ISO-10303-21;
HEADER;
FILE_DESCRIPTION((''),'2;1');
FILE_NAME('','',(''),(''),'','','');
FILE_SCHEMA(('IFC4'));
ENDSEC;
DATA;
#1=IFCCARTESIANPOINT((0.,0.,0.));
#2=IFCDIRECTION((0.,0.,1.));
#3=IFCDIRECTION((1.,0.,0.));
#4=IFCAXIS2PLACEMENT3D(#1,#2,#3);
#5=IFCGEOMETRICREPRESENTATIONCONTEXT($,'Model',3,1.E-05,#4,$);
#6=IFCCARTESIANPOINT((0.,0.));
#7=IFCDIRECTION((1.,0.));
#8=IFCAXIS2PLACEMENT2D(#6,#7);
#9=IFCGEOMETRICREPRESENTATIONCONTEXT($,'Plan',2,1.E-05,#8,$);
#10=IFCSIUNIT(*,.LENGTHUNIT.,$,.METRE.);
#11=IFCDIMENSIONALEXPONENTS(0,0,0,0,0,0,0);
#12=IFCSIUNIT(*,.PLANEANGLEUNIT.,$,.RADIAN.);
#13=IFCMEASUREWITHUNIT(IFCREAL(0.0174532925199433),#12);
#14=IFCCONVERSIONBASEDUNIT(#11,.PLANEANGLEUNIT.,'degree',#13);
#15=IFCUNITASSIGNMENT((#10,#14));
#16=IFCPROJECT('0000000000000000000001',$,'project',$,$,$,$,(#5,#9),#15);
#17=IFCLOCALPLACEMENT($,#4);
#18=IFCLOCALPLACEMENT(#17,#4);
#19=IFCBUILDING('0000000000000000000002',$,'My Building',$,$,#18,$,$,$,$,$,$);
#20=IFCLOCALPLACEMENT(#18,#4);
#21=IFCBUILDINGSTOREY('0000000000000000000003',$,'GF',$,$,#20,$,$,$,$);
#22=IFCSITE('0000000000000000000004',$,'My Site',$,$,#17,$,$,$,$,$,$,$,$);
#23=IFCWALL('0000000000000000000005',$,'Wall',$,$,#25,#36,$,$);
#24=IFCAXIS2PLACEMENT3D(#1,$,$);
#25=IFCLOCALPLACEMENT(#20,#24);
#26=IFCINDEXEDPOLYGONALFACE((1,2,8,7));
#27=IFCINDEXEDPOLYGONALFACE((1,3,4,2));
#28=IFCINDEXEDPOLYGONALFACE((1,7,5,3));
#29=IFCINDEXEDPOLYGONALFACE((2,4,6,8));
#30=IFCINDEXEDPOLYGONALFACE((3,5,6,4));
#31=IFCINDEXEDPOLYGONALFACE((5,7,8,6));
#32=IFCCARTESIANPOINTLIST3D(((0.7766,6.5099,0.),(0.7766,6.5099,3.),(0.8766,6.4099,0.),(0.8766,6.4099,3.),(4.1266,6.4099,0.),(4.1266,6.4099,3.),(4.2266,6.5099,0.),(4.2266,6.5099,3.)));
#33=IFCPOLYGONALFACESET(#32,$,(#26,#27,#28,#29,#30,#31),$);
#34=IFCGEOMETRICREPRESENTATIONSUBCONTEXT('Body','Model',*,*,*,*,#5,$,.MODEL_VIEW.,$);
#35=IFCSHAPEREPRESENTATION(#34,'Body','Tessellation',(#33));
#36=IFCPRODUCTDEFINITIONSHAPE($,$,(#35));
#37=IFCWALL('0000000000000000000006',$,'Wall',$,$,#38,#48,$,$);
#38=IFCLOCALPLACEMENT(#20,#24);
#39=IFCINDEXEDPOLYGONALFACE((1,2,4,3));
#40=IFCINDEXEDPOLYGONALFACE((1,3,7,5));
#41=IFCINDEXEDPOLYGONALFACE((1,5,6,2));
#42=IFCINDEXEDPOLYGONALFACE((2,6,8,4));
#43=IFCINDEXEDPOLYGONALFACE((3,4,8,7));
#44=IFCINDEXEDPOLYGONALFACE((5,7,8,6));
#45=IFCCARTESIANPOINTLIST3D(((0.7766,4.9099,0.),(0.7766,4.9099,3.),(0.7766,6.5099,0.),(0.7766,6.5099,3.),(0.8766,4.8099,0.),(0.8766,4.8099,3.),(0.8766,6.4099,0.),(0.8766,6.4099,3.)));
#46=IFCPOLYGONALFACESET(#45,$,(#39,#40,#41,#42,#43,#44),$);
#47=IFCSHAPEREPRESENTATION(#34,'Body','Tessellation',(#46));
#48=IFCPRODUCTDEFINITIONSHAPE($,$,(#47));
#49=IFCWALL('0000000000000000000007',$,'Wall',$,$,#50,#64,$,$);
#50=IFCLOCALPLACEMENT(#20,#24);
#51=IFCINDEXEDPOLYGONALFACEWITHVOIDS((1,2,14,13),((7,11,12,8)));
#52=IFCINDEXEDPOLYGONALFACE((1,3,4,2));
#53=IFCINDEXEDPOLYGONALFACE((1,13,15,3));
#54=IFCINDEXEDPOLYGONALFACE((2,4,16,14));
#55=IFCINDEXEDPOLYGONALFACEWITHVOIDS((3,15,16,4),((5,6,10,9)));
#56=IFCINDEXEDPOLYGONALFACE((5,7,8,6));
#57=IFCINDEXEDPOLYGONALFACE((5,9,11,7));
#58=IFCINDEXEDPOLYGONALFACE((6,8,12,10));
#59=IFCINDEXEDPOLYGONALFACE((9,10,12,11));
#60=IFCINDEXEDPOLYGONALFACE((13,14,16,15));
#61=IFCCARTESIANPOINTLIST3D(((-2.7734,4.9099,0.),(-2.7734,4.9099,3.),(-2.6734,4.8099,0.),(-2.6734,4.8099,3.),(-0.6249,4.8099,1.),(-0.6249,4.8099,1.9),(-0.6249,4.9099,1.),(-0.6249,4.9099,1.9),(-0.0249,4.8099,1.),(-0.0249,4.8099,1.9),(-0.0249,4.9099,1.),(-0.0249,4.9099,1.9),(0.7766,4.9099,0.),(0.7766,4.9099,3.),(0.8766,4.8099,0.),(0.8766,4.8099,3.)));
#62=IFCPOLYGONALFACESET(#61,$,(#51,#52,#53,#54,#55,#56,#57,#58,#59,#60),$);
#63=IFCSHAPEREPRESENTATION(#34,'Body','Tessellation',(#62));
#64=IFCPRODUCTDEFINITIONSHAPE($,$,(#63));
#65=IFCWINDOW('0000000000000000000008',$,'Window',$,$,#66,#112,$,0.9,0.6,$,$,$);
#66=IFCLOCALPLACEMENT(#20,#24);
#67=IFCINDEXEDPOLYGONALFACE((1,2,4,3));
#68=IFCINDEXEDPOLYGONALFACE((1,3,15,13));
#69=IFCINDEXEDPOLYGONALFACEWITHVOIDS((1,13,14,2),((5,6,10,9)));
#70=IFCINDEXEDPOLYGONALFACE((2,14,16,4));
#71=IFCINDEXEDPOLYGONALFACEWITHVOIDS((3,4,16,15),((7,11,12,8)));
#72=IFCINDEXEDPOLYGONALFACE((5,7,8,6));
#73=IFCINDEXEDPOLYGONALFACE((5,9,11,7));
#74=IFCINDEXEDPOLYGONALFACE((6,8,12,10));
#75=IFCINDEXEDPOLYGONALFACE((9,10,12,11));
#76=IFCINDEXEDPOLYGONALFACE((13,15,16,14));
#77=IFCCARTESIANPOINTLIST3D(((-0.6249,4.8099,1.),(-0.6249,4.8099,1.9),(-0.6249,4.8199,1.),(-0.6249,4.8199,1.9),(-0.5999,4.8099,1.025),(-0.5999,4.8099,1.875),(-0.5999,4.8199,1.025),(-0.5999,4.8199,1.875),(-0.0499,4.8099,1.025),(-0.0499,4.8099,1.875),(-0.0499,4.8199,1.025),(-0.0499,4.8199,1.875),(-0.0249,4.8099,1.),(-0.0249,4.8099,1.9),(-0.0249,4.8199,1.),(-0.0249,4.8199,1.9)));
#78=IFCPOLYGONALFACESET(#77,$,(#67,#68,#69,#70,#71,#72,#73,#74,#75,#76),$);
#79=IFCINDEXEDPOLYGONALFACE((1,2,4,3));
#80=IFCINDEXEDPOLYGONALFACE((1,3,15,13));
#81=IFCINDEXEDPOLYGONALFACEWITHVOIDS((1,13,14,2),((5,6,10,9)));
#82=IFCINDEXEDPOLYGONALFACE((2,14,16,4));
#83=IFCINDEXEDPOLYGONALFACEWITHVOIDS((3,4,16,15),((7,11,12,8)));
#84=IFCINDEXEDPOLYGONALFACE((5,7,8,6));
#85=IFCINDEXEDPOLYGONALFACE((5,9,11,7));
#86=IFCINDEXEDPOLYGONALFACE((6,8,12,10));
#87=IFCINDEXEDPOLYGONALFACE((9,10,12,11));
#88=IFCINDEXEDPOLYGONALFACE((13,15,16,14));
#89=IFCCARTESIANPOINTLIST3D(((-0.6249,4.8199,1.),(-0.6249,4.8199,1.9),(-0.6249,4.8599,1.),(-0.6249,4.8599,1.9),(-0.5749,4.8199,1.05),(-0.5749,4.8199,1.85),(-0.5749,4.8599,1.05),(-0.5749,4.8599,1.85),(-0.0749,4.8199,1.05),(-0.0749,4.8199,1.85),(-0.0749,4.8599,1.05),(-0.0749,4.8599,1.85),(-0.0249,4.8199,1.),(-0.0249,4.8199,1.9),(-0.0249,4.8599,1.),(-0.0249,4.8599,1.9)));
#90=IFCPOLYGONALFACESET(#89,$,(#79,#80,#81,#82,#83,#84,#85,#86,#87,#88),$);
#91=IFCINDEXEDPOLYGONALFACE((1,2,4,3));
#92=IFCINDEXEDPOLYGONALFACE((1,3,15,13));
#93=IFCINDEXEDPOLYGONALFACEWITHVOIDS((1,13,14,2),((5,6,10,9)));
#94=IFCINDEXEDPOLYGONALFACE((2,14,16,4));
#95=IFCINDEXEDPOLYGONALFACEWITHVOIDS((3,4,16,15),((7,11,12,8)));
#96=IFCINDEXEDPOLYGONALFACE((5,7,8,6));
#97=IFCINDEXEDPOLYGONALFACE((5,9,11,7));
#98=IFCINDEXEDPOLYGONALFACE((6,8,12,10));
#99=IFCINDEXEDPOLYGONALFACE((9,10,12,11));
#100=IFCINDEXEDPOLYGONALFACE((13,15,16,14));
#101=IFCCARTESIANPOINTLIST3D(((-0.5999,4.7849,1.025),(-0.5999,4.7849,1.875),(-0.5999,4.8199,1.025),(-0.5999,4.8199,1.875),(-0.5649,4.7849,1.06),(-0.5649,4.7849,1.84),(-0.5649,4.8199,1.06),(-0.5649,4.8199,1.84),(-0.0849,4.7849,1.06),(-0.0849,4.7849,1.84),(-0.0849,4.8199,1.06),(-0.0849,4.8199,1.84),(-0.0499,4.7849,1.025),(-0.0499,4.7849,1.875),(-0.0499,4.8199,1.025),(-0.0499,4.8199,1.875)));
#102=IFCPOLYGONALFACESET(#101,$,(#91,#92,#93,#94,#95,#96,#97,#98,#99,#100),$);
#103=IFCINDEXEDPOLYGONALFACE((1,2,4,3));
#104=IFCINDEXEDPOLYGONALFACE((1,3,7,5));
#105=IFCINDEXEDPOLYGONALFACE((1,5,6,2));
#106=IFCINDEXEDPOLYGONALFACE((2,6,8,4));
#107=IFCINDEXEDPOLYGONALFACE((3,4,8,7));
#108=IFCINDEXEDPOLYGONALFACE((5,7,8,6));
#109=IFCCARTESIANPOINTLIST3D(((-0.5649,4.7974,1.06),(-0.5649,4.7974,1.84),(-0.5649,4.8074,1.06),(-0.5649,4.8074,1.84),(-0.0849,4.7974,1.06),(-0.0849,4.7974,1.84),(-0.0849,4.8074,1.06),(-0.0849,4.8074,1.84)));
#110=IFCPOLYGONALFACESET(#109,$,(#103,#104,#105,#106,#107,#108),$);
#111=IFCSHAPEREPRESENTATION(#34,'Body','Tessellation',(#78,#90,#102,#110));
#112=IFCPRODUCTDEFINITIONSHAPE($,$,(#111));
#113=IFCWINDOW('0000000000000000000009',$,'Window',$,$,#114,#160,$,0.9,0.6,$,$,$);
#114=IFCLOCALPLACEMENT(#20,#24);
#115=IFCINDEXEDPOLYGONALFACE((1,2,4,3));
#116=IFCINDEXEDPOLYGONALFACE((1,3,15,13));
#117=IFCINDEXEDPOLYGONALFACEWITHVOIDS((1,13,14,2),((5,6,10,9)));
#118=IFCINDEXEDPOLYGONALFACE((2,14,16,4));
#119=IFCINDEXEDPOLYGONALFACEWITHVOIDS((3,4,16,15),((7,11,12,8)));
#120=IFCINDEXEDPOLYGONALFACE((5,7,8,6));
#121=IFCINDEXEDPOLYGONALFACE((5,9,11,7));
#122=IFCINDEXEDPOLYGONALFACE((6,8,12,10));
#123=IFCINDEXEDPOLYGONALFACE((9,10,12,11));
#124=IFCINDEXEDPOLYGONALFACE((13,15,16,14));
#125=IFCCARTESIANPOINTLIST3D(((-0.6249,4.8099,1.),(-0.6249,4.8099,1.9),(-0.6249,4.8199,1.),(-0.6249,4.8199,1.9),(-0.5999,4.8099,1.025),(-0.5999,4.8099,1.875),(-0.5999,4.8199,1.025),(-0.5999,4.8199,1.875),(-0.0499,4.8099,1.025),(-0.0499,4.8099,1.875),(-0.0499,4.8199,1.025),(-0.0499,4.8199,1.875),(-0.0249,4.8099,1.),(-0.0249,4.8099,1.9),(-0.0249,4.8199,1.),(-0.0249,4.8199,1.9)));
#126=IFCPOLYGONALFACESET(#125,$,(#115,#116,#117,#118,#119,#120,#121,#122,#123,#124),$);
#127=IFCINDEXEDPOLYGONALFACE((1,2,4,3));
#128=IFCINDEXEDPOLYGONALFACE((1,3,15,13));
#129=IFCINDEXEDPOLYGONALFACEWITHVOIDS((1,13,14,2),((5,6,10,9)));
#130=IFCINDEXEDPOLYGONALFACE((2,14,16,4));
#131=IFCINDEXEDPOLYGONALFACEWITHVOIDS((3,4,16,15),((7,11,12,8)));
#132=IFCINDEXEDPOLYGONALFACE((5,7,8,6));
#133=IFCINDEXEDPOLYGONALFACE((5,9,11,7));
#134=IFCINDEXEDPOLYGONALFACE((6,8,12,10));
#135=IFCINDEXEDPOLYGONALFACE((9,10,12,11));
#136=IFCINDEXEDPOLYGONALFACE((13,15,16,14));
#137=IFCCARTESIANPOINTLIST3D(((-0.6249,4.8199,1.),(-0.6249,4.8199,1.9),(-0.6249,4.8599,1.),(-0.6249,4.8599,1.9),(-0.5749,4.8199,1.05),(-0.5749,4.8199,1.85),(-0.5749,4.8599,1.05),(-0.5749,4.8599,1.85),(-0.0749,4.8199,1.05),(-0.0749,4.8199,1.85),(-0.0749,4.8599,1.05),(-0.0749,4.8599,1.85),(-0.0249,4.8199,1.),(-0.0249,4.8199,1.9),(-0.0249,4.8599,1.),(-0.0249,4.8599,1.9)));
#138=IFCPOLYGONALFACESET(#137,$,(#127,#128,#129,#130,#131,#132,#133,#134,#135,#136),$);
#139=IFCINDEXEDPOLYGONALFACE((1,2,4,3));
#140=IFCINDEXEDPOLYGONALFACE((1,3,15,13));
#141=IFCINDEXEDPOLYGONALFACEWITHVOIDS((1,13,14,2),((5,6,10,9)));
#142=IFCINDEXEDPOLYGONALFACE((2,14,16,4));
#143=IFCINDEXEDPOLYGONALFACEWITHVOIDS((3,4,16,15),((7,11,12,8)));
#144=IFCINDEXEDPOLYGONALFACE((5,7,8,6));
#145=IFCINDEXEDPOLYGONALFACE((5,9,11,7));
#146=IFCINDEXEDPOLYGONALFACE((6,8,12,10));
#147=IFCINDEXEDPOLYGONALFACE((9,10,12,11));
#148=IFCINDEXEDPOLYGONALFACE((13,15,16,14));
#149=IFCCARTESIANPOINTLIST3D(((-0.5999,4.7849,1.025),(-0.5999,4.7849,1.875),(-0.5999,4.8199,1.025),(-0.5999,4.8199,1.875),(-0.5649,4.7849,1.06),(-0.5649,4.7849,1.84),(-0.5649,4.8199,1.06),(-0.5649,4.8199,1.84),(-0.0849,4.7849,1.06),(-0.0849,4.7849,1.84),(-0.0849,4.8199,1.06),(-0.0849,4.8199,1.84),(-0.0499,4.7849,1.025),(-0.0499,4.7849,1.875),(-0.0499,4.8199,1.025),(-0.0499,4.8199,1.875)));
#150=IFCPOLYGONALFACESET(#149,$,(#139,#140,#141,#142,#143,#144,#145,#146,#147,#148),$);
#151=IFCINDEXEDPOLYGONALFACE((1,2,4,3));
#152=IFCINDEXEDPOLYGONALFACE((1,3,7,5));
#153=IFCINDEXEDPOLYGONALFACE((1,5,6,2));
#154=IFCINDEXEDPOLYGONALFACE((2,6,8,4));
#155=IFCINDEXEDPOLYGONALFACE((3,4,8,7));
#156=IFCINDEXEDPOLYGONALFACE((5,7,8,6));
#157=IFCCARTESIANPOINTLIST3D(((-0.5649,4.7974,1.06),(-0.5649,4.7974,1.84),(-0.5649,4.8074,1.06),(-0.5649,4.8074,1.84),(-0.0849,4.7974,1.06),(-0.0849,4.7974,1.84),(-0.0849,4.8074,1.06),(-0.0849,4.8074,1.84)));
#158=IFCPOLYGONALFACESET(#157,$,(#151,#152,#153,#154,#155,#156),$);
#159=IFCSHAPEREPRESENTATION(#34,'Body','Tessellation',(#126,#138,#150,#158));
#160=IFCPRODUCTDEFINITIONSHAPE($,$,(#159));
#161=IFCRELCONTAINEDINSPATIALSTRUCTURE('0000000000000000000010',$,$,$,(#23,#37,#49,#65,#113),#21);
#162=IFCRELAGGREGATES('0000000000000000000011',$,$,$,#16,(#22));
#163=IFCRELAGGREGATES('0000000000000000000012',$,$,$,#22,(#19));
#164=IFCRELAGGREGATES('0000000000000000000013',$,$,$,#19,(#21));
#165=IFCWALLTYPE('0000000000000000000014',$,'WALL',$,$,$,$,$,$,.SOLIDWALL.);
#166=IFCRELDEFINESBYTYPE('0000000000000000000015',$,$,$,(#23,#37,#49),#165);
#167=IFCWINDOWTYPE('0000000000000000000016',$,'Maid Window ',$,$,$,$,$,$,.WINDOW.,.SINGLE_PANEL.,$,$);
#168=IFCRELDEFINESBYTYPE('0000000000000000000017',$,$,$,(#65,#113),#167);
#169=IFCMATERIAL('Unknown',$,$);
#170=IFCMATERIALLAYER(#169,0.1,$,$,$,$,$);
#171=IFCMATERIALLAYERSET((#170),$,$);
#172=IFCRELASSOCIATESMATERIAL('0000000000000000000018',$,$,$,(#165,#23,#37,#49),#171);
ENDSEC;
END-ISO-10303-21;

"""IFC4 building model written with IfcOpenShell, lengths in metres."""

from ifc_helpers import new_model, entity, si_unit, converted_unit, frame, origin_with_axes, origin_2d_with_axis, place, context, subcontext, project, spatial, line, indexed_curve, outline, extrude, shape, source, transform, mapped, material, layer, layer_set, layer_usage, type_object, type_shapes, element, fill, save


model = new_model("IFC4")

# Units and contexts
model_context = context("Model", 3, precision=1e-05, world=origin_with_axes())
plan_context = context("Plan", 2, precision=1e-05, world=origin_2d_with_axis())
body_context_1 = subcontext(model_context, "Body", "Model", "MODEL_VIEW")
body_context_2 = subcontext(plan_context, "Body", "Plan", "PLAN_VIEW")
ifc_project = project(units=[si_unit("LENGTHUNIT", "METRE"), converted_unit("PLANEANGLEUNIT", "degree", entity("IfcReal", 0.0174532925199433), si_unit("PLANEANGLEUNIT", "RADIAN"), dimensions=[0, 0, 0, 0, 0, 0, 0])], contexts=[model_context, plan_context])

# Site, building, storey
site_placement = place(None, origin_with_axes())
site = spatial("IfcSite", under=ifc_project, at=site_placement, Name="My Site")
building_placement = place(site_placement, origin_with_axes())
building = spatial("IfcBuilding", under=site, at=building_placement, Name="My Building")
storey_placement = place(building_placement, origin_with_axes())
storey = spatial("IfcBuildingStorey", under=building, at=storey_placement, Name="GF")

# Walls
ifc_material = material(Name="Unknown")
ifc_layer = layer(ifc_material, 0.1)
ifc_layer_set = layer_set([ifc_layer])
ifc_layer_usage_1 = layer_usage(ifc_layer_set, "AXIS2", "POSITIVE", 0.0)
wall_type = type_object("IfcWallType", Name="WALL", PredefinedType="SOLIDWALL", material=ifc_layer_set)
wall_1_placement = place(storey_placement, frame((4.2266, 6.5099, 0.0), z_axis=(0.0, 0.0, 1.0), x_axis=(-1.0, 0.0, 0.0)))
element("IfcWall", 1, at=wall_1_placement, inside=storey, type_object=wall_type, material=ifc_layer_usage_1, Name="Wall", context=body_context_1, shape_type="SweptSolid", body=[
    extrude(outline(indexed_curve([(0.0, 0.0), (0.1, 0.1), (3.35, 0.1), (3.45, 0.0)], segments=[line(1, 2, 3, 4, 1)])), origin_with_axes(), (0.0, 0.0, 1.0), 3.0),
])
ifc_layer_usage_2 = layer_usage(ifc_layer_set, "AXIS2", "POSITIVE", 0.0)
wall_2_placement = place(storey_placement, frame((0.7766, 6.5099, 0.0), z_axis=(0.0, 0.0, 1.0), x_axis=(0.0, -1.0, 0.0)))
element("IfcWall", 2, at=wall_2_placement, inside=storey, type_object=wall_type, material=ifc_layer_usage_2, Name="Wall", context=body_context_1, shape_type="SweptSolid", body=[
    extrude(outline(indexed_curve([(0.0, 0.0), (0.1, 0.1), (1.7, 0.1), (1.6, 0.0)], segments=[line(1, 2, 3, 4, 1)])), origin_with_axes(), (0.0, 0.0, 1.0), 3.0),
])

# Wall, openings, windows
ifc_layer_usage_3 = layer_usage(ifc_layer_set, "AXIS2", "POSITIVE", 0.0)
wall_3_placement = place(storey_placement, frame((0.7766, 4.9099, 0.0), z_axis=(0.0, 0.0, 1.0), x_axis=(-1.0, 0.0, 0.0)))
wall_3 = element("IfcWall", 3, at=wall_3_placement, inside=storey, type_object=wall_type, material=ifc_layer_usage_3, Name="Wall", context=body_context_1, shape_type="SweptSolid", body=[
    extrude(outline(indexed_curve([(0.0, 0.0), (-0.1, 0.1), (3.45, 0.1), (3.55, 0.0)], segments=[line(1, 2, 3, 4, 1)])), origin_with_axes(), (0.0, 0.0, 1.0), 3.0),
])
shared_shape_1 = source(origin_with_axes(), body_context_1, "Body", "SweptSolid", [
    extrude(outline(indexed_curve([(0.0, 0.0), (0.6, 0.0), (0.6, 0.9), (0.0, 0.9)], segments=[line(1, 2, 3, 4, 1)])), frame((0.0, -0.6, 0.0), z_axis=(0.0, -1.0, 0.0), x_axis=(1.0, 0.0, 0.0)), (0.0, 0.0, -1.0), 1.2),
])
opening_1_placement = place(wall_3_placement, frame((0.8015, 0.0, 1.0), z_axis=(0.0, 0.0, 1.0), x_axis=(1.0, 0.0, 0.0)))
opening_1 = element("IfcOpeningElement", 4, at=opening_1_placement, cuts=wall_3, PredefinedType="OPENING", context=body_context_1, shape_type="MappedRepresentation", body=[
    mapped(shared_shape_1, transform((0.0, 0.0, 0.0), x_axis=(1.0, 0.0, 0.0), y_axis=(0.0, 1.0, 0.0), z_axis=(0.0, 0.0, 1.0), scale=1.0)),
])
opening_2_placement = place(wall_3_placement, frame((0.8015, 0.0, 1.0), z_axis=(0.0, 0.0, 1.0), x_axis=(1.0, 0.0, 0.0)))
opening_2 = element("IfcOpeningElement", 5, at=opening_2_placement, cuts=wall_3, PredefinedType="OPENING", context=body_context_1, shape_type="MappedRepresentation", body=[
    mapped(shared_shape_1, transform((0.0, 0.0, 0.0), x_axis=(1.0, 0.0, 0.0), y_axis=(0.0, 1.0, 0.0), z_axis=(0.0, 0.0, 1.0), scale=1.0)),
])
window_type_1 = type_object("IfcWindowType", Name="Maid Window ", PartitioningType="SINGLE_PANEL", PredefinedType="WINDOW")
shared_shape_2 = source(origin_with_axes(), body_context_1, "Body", "SweptSolid", [
    extrude(outline(indexed_curve([(0.0, 0.0), (0.6, 0.0), (0.6, 0.9), (0.0, 0.9)], segments=[line(1, 2, 3, 4, 1)]), holes=[indexed_curve([(0.025, 0.025), (0.575, 0.025), (0.575, 0.875), (0.025, 0.875)], segments=[line(1, 2, 3, 4, 1)])]), frame((0.0, 0.09, 0.0), z_axis=(0.0, -1.0, 0.0), x_axis=(1.0, 0.0, 0.0)), (0.0, 0.0, -1.0), 0.01),
    extrude(outline(indexed_curve([(0.0, 0.0), (0.6, 0.0), (0.6, 0.9), (0.0, 0.9)], segments=[line(1, 2, 3, 4, 1)]), holes=[indexed_curve([(0.05, 0.05), (0.55, 0.05), (0.55, 0.85), (0.05, 0.85)], segments=[line(1, 2, 3, 4, 1)])]), frame((0.0, 0.05, 0.0), z_axis=(0.0, -1.0, 0.0), x_axis=(1.0, 0.0, 0.0)), (0.0, 0.0, -1.0), 0.04),
    extrude(outline(indexed_curve([(0.0, 0.0), (0.55, 0.0), (0.55, 0.85), (0.0, 0.85)], segments=[line(1, 2, 3, 4, 1)]), holes=[indexed_curve([(0.035, 0.035), (0.515, 0.035), (0.515, 0.815), (0.035, 0.815)], segments=[line(1, 2, 3, 4, 1)])]), frame((0.025, 0.09, 0.025), z_axis=(0.0, -1.0, 0.0), x_axis=(1.0, 0.0, 0.0)), (0.0, 0.0, -1.0), 0.035),
    extrude(outline(indexed_curve([(0.035, 0.035), (0.515, 0.035), (0.515, 0.815), (0.035, 0.815)], segments=[line(1, 2, 3, 4, 1)])), frame((0.025, 0.1025, 0.025), z_axis=(0.0, -1.0, 0.0), x_axis=(1.0, 0.0, 0.0)), (0.0, 0.0, -1.0), 0.01),
])
shared_shape_3 = source(origin_with_axes(), body_context_2, "Body", "Curve2D", [
    entity("IfcIndexedPolyCurve", entity("IfcCartesianPointList2D", [[0.05, 0.05], [0.55, 0.05]])),
    entity("IfcIndexedPolyCurve", entity("IfcCartesianPointList2D", [[0.0, 0.1], [0.025, 0.1], [0.025, 0.09], [0.05, 0.09], [0.05, 0.05], [0.0, 0.05]]), [entity("IfcLineIndex", [1, 2, 3, 4, 5, 6, 1])]),
    entity("IfcIndexedPolyCurve", entity("IfcCartesianPointList2D", [[0.6, 0.1], [0.575, 0.1], [0.575, 0.09], [0.55, 0.09], [0.55, 0.05], [0.6, 0.05]]), [entity("IfcLineIndex", [1, 2, 3, 4, 5, 6, 1])]),
    entity("IfcIndexedPolyCurve", entity("IfcCartesianPointList2D", [[0.025, 0.09], [0.06, 0.09], [0.06, 0.125], [0.025, 0.125]]), [entity("IfcLineIndex", [1, 2, 3, 4, 1])]),
    entity("IfcIndexedPolyCurve", entity("IfcCartesianPointList2D", [[0.575, 0.09], [0.54, 0.09], [0.54, 0.125], [0.575, 0.125]]), [entity("IfcLineIndex", [1, 2, 3, 4, 1])]),
    entity("IfcIndexedPolyCurve", entity("IfcCartesianPointList2D", [[0.06, 0.09], [0.54, 0.09]])),
    entity("IfcIndexedPolyCurve", entity("IfcCartesianPointList2D", [[0.06, 0.125], [0.54, 0.125]])),
    entity("IfcIndexedPolyCurve", entity("IfcCartesianPointList2D", [[0.06, 0.1075], [0.54, 0.1075]])),
])
type_shapes(window_type_1, [shared_shape_2, shared_shape_3])
window_1_placement = place(opening_1_placement, frame((0.0, 0.0, 0.0), z_axis=(0.0, 0.0, 1.0), x_axis=(1.0, 0.0, 0.0)))
window_1 = element("IfcWindow", 6, at=window_1_placement, inside=storey, type_object=window_type_1, Name="Window", OverallHeight=0.9, OverallWidth=0.6, shapes=[
    shape(body_context_1, "Body", "MappedRepresentation", [mapped(shared_shape_2, transform((0.0, 0.0, 0.0), x_axis=(1.0, 0.0, 0.0), y_axis=(0.0, 1.0, 0.0), z_axis=(0.0, 0.0, 1.0), scale=1.0))]),
    shape(body_context_2, "Body", "MappedRepresentation", [mapped(shared_shape_3, transform((0.0, 0.0, 0.0), x_axis=(1.0, 0.0, 0.0), y_axis=(0.0, 1.0, 0.0), z_axis=(0.0, 0.0, 1.0), scale=1.0))]),
])
fill(opening_1, window_1)
window_2_placement = place(opening_2_placement, frame((0.0, 0.0, 0.0), z_axis=(0.0, 0.0, 1.0), x_axis=(1.0, 0.0, 0.0)))
window_2 = element("IfcWindow", 7, at=window_2_placement, inside=storey, type_object=window_type_1, Name="Window", OverallHeight=0.9, OverallWidth=0.6, shapes=[
    shape(body_context_1, "Body", "MappedRepresentation", [mapped(shared_shape_2, transform((0.0, 0.0, 0.0), x_axis=(1.0, 0.0, 0.0), y_axis=(0.0, 1.0, 0.0), z_axis=(0.0, 0.0, 1.0), scale=1.0))]),
    shape(body_context_2, "Body", "MappedRepresentation", [mapped(shared_shape_3, transform((0.0, 0.0, 0.0), x_axis=(1.0, 0.0, 0.0), y_axis=(0.0, 1.0, 0.0), z_axis=(0.0, 0.0, 1.0), scale=1.0))]),
])
fill(opening_2, window_2)

save(model, "model.ifc")
